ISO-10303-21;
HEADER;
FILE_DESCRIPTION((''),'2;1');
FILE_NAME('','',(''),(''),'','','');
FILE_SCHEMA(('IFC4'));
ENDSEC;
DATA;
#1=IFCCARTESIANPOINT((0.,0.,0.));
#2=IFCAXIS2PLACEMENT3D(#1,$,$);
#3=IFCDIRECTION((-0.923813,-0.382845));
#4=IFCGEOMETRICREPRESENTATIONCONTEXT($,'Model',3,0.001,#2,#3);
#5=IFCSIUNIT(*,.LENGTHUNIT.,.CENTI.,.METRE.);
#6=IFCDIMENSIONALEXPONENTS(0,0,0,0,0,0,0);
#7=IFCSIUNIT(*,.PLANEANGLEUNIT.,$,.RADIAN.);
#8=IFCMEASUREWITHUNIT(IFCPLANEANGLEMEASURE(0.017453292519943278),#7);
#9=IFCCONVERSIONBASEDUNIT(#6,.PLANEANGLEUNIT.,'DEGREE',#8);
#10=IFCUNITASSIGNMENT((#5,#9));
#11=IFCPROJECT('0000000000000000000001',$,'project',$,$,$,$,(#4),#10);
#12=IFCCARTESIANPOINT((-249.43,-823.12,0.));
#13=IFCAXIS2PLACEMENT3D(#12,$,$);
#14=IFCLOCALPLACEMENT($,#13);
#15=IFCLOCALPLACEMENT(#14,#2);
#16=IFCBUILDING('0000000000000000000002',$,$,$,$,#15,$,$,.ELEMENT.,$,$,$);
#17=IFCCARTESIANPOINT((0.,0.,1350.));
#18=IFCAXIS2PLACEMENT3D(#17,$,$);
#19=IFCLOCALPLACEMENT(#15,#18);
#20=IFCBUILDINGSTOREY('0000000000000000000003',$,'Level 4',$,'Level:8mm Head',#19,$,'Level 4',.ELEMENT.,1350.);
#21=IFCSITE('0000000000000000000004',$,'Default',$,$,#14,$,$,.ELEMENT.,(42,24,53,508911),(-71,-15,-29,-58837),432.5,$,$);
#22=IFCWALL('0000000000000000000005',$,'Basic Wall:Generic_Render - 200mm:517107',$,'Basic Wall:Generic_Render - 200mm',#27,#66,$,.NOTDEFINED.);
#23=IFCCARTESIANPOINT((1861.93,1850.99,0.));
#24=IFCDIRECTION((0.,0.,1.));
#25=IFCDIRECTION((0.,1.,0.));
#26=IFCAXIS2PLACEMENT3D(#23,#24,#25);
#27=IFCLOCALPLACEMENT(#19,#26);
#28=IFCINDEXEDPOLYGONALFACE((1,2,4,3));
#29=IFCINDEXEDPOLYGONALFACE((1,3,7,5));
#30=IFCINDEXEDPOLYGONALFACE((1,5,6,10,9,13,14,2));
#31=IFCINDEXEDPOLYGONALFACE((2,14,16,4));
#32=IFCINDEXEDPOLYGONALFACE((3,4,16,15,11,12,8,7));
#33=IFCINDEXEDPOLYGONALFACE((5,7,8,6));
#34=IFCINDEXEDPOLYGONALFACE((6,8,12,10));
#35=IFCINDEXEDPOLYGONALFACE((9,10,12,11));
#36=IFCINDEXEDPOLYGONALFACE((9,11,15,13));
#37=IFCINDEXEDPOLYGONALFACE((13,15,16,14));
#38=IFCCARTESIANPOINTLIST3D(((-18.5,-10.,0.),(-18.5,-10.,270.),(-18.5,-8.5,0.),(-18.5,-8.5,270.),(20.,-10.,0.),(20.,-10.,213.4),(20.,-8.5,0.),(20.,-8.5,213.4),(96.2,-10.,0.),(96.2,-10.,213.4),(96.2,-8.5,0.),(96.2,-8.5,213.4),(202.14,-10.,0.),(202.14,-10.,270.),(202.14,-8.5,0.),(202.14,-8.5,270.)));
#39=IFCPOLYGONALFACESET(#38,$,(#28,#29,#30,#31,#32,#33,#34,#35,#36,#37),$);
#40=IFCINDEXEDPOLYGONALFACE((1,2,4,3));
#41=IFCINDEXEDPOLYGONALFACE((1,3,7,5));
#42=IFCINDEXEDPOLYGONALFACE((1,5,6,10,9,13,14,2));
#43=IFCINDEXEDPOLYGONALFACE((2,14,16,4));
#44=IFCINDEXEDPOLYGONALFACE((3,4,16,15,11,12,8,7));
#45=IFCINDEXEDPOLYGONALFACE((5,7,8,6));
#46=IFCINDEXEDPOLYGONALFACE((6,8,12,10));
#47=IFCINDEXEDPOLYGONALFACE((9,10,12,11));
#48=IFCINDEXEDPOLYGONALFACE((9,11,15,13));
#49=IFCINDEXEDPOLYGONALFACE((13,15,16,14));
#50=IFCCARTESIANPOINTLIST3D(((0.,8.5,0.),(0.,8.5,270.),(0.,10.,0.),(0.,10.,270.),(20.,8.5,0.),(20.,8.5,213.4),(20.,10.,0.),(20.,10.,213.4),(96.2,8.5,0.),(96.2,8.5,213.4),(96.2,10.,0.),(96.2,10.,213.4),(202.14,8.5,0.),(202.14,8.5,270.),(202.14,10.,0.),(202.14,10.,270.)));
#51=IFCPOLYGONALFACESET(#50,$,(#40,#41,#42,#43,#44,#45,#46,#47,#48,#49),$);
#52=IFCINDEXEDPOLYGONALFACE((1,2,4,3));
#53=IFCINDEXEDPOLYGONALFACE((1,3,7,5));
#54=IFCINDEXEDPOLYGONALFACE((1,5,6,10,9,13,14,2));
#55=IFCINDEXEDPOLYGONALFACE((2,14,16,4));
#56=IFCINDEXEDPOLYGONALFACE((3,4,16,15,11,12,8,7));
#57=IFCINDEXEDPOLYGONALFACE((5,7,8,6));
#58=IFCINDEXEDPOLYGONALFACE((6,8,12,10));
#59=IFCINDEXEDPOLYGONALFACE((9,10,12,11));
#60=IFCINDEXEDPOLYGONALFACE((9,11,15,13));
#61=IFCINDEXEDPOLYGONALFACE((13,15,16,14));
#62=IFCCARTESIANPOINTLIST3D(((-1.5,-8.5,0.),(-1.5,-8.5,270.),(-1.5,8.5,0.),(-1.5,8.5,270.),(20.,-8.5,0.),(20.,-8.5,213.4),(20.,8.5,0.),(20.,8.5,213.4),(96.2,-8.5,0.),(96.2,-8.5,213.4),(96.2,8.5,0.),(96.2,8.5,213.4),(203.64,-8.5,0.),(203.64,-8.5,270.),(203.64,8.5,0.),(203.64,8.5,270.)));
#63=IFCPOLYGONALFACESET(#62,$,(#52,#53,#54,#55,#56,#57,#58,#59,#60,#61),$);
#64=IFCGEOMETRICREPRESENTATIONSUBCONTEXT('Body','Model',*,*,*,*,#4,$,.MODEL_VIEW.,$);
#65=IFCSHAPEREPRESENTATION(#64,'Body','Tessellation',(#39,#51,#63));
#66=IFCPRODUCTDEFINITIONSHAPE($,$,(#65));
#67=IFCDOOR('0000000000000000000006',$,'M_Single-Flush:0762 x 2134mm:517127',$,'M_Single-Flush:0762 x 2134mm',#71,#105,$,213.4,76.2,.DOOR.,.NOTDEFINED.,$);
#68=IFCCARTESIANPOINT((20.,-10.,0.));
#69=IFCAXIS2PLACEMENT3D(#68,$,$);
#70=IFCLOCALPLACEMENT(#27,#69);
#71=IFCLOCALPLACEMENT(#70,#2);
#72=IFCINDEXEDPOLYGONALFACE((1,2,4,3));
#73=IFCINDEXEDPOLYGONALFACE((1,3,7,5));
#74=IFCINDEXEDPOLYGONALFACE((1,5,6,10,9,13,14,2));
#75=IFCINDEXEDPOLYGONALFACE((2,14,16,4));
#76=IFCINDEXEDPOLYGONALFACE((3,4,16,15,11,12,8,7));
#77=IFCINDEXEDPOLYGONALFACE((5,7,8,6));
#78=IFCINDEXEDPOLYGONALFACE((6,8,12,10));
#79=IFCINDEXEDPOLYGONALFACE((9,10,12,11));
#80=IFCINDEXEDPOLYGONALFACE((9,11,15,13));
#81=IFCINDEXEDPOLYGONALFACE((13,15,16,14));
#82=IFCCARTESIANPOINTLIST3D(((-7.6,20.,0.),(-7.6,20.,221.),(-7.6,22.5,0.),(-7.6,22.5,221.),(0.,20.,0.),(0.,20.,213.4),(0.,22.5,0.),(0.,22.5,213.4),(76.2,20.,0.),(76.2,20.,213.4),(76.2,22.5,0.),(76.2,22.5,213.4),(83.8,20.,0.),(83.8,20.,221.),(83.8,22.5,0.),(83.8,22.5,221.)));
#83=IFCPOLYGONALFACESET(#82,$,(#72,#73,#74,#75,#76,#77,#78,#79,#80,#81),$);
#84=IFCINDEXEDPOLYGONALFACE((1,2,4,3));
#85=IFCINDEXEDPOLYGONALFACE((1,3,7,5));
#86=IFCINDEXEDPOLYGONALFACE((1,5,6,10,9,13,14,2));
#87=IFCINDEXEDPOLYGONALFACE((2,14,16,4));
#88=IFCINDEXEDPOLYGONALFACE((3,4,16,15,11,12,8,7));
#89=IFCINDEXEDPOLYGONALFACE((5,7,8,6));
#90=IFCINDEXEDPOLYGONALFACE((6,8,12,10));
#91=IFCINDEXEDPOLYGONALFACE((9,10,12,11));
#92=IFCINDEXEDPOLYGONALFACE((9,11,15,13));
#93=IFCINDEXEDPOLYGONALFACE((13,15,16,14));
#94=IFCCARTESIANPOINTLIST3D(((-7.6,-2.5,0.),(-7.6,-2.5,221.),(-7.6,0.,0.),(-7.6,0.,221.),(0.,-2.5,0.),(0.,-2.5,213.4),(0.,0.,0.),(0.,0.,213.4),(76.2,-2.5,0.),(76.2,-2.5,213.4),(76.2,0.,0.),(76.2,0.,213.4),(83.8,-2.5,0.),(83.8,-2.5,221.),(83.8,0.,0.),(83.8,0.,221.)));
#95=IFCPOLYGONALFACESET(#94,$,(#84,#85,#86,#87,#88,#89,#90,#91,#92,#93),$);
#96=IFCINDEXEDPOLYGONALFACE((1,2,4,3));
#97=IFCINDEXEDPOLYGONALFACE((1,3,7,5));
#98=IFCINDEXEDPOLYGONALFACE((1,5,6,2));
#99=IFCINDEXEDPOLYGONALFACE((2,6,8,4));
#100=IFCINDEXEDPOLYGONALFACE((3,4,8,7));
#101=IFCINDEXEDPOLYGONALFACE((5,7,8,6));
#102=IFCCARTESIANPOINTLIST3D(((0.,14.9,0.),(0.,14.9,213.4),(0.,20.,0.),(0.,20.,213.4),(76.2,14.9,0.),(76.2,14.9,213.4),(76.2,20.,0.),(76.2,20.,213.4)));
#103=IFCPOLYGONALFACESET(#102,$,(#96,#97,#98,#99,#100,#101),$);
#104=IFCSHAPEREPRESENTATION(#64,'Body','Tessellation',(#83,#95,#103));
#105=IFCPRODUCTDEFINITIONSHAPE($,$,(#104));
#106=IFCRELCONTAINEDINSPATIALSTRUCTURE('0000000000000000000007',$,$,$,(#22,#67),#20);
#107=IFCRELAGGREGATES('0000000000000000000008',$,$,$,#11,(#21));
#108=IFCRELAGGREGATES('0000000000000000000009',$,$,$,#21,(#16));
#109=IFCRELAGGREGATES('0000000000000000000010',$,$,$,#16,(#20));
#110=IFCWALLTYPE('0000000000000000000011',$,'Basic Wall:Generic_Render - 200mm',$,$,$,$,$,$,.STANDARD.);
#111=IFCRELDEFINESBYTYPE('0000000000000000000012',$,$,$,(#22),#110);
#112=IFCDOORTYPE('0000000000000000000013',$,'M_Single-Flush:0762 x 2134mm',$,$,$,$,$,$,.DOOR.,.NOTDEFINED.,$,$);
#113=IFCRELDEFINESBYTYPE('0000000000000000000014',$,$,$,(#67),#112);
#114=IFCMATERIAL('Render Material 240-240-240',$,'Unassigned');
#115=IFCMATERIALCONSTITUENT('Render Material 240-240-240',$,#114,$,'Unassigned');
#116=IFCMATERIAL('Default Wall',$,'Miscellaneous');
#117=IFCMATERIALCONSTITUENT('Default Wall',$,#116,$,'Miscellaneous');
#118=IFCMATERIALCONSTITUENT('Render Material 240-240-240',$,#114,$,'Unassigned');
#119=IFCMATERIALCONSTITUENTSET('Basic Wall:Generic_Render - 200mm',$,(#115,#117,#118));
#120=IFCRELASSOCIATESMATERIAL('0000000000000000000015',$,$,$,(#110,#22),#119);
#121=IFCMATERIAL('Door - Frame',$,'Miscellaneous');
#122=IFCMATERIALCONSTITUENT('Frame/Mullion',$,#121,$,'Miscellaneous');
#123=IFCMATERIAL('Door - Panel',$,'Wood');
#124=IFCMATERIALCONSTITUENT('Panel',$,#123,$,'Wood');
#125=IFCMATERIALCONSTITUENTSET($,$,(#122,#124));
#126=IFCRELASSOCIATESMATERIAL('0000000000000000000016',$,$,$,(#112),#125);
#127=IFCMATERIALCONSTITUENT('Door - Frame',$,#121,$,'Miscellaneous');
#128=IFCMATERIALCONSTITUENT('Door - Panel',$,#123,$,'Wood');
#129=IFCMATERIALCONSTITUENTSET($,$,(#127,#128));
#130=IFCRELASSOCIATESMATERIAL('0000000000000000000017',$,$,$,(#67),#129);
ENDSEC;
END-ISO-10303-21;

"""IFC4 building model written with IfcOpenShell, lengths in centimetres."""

from ifc_helpers import new_model, entity, si_unit, converted_unit, direction, frame, origin, place, context, subcontext, project, spatial, indexed_curve, outline, extrude, source, transform, mapped, material, constituent, constituent_set, type_object, type_shapes, element, fill, save


model = new_model("IFC4")

# Units and contexts
model_context = context("Model", 3, precision=0.001, world=origin(), true_north=direction((-0.923813, -0.382845)))
body_context = subcontext(model_context, "Body", "Model", "MODEL_VIEW")
ifc_project = project(units=[si_unit("LENGTHUNIT", "METRE", prefix="CENTI"), converted_unit("PLANEANGLEUNIT", "DEGREE", entity("IfcPlaneAngleMeasure", 0.017453292519943278), si_unit("PLANEANGLEUNIT", "RADIAN"), dimensions=[0, 0, 0, 0, 0, 0, 0])], contexts=[model_context])

# Site, building, storey
site_placement = place(None, frame((-249.43, -823.12, 0.0)))
site = spatial("IfcSite", under=ifc_project, at=site_placement, Name="Default", CompositionType="ELEMENT", RefLatitude=(42, 24, 53, 508911), RefLongitude=(-71, -15, -29, -58837), RefElevation=432.5)
building_placement = place(site_placement, origin())
building = spatial("IfcBuilding", under=site, at=building_placement, CompositionType="ELEMENT")
storey_placement = place(building_placement, frame((0.0, 0.0, 1350.0)))
storey = spatial("IfcBuildingStorey", under=building, at=storey_placement, Name="Level 4", ObjectType="Level:8mm Head", LongName="Level 4", CompositionType="ELEMENT", Elevation=1350.0)

# Shared definitions
ifc_material_1 = material(Name="Render Material 240-240-240", Category="Unassigned")
ifc_material_2 = material(Name="Default Wall", Category="Miscellaneous")
ifc_constituent_1 = constituent(ifc_material_1, Name="Render Material 240-240-240", Category="Unassigned")
ifc_constituent_2 = constituent(ifc_material_2, Name="Default Wall", Category="Miscellaneous")
ifc_constituent_3 = constituent(ifc_material_1, Name="Render Material 240-240-240", Category="Unassigned")
ifc_constituent_set_1 = constituent_set(constituents=[ifc_constituent_1, ifc_constituent_2, ifc_constituent_3], Name="Basic Wall:Generic_Render - 200mm")
wall_type_1 = type_object("IfcWallType", Name="Basic Wall:Generic_Render - 200mm", PredefinedType="STANDARD", material=ifc_constituent_set_1)

# Shared definitions
ifc_material_3 = material(Name="Door - Frame", Category="Miscellaneous")
ifc_material_4 = material(Name="Door - Panel", Category="Wood")

# Wall, opening, door
wall_1_placement = place(storey_placement, frame((1861.93, 1850.99, 0.0), z_axis=(0.0, 0.0, 1.0), x_axis=(0.0, 1.0, 0.0)))
wall_1 = element("IfcWall", 1, at=wall_1_placement, inside=storey, type_object=wall_type_1, material=ifc_constituent_set_1, Name="Basic Wall:Generic_Render - 200mm:517107", ObjectType="Basic Wall:Generic_Render - 200mm", PredefinedType="NOTDEFINED", context=body_context, shape_type="SweptSolid", body=[
    extrude(outline(indexed_curve([(-120.85, -127.18), (149.15, -127.18), (149.15, 93.46), (-120.85, 93.46), (-120.85, 54.96), (92.55, 54.96), (92.55, -21.24), (-120.85, -21.24), (-120.85, -127.18)], self_intersect=False)), frame((74.96, -8.5, 120.85), z_axis=(0.0, -1.0, 0.0), x_axis=(0.0, 0.0, 1.0)), (0.0, 0.0, 1.0), 1.5),
    extrude(outline(indexed_curve([(-59.58, -92.55), (-59.58, 120.85), (-79.58, 120.85), (-79.58, -149.15), (122.55, -149.15), (122.55, 120.85), (16.62, 120.85), (16.62, -92.55), (-59.58, -92.55)], self_intersect=False)), frame((79.58, 10.0, 120.85), z_axis=(0.0, 1.0, 0.0), x_axis=(1.0, 0.0, 0.0)), (0.0, 0.0, -1.0), 1.5),
    extrude(outline(indexed_curve([(-120.85, -124.05), (149.15, -124.05), (149.15, 81.08), (-120.85, 81.08), (-120.85, 59.58), (92.55, 59.58), (92.55, -16.62), (-120.85, -16.62), (-120.85, -124.05)], self_intersect=False)), frame((79.58, 8.5, 120.85), z_axis=(0.0, -1.0, 0.0), x_axis=(0.0, 0.0, 1.0)), (0.0, 0.0, 1.0), 17.0),
])
opening_1_placement = place(wall_1_placement, frame((20.0, -10.0, 0.0)))
opening_1 = element("IfcOpeningElement", 2, at=opening_1_placement, cuts=wall_1, PredefinedType="OPENING", context=body_context, shape_type="SweptSolid", body=[
    extrude(outline(indexed_curve([(0.0, 76.2), (0.0, 0.0), (213.4, 0.0), (213.4, 76.2), (0.0, 76.2)], self_intersect=False)), frame((0.0, 0.0, 0.0), z_axis=(0.0, 1.0, 0.0), x_axis=(0.0, 0.0, 1.0)), (0.0, 0.0, 1.0), 20.0),
])
ifc_constituent_4 = constituent(ifc_material_3, Name="Door - Frame", Category="Miscellaneous")
ifc_constituent_5 = constituent(ifc_material_4, Name="Door - Panel", Category="Wood")
ifc_constituent_set_2 = constituent_set(constituents=[ifc_constituent_4, ifc_constituent_5])
ifc_constituent_6 = constituent(ifc_material_3, Name="Frame/Mullion", Category="Miscellaneous")
ifc_constituent_7 = constituent(ifc_material_4, Name="Panel", Category="Wood")
ifc_constituent_set_3 = constituent_set(constituents=[ifc_constituent_6, ifc_constituent_7])
door_type_1 = type_object("IfcDoorType", Name="M_Single-Flush:0762 x 2134mm", OperationType="NOTDEFINED", PredefinedType="DOOR", material=ifc_constituent_set_3)
shared_shape_1 = source(origin(), body_context, "Body", "SweptSolid", [
    extrude(outline(indexed_curve([(-45.7, -112.4), (45.7, -112.4), (45.7, 108.6), (38.1, 108.6), (38.1, -104.8), (-38.1, -104.8), (-38.1, 108.6), (-45.7, 108.6), (-45.7, -112.4)], self_intersect=False)), frame((38.1, 22.5, 108.6), z_axis=(0.0, -1.0, 0.0), x_axis=(-1.0, 0.0, 0.0)), (0.0, 0.0, 1.0), 2.5),
    extrude(outline(indexed_curve([(-112.4, -45.7), (108.6, -45.7), (108.6, -38.1), (-104.8, -38.1), (-104.8, 38.1), (108.6, 38.1), (108.6, 45.7), (-112.4, 45.7), (-112.4, -45.7)], self_intersect=False)), frame((38.1, 0.0, 108.6), z_axis=(0.0, -1.0, 0.0), x_axis=(0.0, 0.0, -1.0)), (0.0, 0.0, 1.0), 2.5),
    extrude(outline(indexed_curve([(-38.1, -2.55), (38.1, -2.55), (38.1, 2.55), (-38.1, 2.55), (-38.1, -2.55)], self_intersect=False)), frame((38.1, 17.45, 0.0)), (0.0, 0.0, 1.0), 213.4),
])
type_shapes(door_type_1, [shared_shape_1])
door_1_placement = place(opening_1_placement, origin())
door_1 = element("IfcDoor", 3, at=door_1_placement, inside=storey, type_object=door_type_1, material=ifc_constituent_set_2, Name="M_Single-Flush:0762 x 2134mm:517127", ObjectType="M_Single-Flush:0762 x 2134mm", OperationType="NOTDEFINED", OverallHeight=213.4, OverallWidth=76.2, PredefinedType="DOOR", context=body_context, shape_type="MappedRepresentation", body=[
    mapped(shared_shape_1, transform((0.0, 0.0, 0.0), scale=1.0)),
])
fill(opening_1, door_1)

save(model, "model.ifc")
